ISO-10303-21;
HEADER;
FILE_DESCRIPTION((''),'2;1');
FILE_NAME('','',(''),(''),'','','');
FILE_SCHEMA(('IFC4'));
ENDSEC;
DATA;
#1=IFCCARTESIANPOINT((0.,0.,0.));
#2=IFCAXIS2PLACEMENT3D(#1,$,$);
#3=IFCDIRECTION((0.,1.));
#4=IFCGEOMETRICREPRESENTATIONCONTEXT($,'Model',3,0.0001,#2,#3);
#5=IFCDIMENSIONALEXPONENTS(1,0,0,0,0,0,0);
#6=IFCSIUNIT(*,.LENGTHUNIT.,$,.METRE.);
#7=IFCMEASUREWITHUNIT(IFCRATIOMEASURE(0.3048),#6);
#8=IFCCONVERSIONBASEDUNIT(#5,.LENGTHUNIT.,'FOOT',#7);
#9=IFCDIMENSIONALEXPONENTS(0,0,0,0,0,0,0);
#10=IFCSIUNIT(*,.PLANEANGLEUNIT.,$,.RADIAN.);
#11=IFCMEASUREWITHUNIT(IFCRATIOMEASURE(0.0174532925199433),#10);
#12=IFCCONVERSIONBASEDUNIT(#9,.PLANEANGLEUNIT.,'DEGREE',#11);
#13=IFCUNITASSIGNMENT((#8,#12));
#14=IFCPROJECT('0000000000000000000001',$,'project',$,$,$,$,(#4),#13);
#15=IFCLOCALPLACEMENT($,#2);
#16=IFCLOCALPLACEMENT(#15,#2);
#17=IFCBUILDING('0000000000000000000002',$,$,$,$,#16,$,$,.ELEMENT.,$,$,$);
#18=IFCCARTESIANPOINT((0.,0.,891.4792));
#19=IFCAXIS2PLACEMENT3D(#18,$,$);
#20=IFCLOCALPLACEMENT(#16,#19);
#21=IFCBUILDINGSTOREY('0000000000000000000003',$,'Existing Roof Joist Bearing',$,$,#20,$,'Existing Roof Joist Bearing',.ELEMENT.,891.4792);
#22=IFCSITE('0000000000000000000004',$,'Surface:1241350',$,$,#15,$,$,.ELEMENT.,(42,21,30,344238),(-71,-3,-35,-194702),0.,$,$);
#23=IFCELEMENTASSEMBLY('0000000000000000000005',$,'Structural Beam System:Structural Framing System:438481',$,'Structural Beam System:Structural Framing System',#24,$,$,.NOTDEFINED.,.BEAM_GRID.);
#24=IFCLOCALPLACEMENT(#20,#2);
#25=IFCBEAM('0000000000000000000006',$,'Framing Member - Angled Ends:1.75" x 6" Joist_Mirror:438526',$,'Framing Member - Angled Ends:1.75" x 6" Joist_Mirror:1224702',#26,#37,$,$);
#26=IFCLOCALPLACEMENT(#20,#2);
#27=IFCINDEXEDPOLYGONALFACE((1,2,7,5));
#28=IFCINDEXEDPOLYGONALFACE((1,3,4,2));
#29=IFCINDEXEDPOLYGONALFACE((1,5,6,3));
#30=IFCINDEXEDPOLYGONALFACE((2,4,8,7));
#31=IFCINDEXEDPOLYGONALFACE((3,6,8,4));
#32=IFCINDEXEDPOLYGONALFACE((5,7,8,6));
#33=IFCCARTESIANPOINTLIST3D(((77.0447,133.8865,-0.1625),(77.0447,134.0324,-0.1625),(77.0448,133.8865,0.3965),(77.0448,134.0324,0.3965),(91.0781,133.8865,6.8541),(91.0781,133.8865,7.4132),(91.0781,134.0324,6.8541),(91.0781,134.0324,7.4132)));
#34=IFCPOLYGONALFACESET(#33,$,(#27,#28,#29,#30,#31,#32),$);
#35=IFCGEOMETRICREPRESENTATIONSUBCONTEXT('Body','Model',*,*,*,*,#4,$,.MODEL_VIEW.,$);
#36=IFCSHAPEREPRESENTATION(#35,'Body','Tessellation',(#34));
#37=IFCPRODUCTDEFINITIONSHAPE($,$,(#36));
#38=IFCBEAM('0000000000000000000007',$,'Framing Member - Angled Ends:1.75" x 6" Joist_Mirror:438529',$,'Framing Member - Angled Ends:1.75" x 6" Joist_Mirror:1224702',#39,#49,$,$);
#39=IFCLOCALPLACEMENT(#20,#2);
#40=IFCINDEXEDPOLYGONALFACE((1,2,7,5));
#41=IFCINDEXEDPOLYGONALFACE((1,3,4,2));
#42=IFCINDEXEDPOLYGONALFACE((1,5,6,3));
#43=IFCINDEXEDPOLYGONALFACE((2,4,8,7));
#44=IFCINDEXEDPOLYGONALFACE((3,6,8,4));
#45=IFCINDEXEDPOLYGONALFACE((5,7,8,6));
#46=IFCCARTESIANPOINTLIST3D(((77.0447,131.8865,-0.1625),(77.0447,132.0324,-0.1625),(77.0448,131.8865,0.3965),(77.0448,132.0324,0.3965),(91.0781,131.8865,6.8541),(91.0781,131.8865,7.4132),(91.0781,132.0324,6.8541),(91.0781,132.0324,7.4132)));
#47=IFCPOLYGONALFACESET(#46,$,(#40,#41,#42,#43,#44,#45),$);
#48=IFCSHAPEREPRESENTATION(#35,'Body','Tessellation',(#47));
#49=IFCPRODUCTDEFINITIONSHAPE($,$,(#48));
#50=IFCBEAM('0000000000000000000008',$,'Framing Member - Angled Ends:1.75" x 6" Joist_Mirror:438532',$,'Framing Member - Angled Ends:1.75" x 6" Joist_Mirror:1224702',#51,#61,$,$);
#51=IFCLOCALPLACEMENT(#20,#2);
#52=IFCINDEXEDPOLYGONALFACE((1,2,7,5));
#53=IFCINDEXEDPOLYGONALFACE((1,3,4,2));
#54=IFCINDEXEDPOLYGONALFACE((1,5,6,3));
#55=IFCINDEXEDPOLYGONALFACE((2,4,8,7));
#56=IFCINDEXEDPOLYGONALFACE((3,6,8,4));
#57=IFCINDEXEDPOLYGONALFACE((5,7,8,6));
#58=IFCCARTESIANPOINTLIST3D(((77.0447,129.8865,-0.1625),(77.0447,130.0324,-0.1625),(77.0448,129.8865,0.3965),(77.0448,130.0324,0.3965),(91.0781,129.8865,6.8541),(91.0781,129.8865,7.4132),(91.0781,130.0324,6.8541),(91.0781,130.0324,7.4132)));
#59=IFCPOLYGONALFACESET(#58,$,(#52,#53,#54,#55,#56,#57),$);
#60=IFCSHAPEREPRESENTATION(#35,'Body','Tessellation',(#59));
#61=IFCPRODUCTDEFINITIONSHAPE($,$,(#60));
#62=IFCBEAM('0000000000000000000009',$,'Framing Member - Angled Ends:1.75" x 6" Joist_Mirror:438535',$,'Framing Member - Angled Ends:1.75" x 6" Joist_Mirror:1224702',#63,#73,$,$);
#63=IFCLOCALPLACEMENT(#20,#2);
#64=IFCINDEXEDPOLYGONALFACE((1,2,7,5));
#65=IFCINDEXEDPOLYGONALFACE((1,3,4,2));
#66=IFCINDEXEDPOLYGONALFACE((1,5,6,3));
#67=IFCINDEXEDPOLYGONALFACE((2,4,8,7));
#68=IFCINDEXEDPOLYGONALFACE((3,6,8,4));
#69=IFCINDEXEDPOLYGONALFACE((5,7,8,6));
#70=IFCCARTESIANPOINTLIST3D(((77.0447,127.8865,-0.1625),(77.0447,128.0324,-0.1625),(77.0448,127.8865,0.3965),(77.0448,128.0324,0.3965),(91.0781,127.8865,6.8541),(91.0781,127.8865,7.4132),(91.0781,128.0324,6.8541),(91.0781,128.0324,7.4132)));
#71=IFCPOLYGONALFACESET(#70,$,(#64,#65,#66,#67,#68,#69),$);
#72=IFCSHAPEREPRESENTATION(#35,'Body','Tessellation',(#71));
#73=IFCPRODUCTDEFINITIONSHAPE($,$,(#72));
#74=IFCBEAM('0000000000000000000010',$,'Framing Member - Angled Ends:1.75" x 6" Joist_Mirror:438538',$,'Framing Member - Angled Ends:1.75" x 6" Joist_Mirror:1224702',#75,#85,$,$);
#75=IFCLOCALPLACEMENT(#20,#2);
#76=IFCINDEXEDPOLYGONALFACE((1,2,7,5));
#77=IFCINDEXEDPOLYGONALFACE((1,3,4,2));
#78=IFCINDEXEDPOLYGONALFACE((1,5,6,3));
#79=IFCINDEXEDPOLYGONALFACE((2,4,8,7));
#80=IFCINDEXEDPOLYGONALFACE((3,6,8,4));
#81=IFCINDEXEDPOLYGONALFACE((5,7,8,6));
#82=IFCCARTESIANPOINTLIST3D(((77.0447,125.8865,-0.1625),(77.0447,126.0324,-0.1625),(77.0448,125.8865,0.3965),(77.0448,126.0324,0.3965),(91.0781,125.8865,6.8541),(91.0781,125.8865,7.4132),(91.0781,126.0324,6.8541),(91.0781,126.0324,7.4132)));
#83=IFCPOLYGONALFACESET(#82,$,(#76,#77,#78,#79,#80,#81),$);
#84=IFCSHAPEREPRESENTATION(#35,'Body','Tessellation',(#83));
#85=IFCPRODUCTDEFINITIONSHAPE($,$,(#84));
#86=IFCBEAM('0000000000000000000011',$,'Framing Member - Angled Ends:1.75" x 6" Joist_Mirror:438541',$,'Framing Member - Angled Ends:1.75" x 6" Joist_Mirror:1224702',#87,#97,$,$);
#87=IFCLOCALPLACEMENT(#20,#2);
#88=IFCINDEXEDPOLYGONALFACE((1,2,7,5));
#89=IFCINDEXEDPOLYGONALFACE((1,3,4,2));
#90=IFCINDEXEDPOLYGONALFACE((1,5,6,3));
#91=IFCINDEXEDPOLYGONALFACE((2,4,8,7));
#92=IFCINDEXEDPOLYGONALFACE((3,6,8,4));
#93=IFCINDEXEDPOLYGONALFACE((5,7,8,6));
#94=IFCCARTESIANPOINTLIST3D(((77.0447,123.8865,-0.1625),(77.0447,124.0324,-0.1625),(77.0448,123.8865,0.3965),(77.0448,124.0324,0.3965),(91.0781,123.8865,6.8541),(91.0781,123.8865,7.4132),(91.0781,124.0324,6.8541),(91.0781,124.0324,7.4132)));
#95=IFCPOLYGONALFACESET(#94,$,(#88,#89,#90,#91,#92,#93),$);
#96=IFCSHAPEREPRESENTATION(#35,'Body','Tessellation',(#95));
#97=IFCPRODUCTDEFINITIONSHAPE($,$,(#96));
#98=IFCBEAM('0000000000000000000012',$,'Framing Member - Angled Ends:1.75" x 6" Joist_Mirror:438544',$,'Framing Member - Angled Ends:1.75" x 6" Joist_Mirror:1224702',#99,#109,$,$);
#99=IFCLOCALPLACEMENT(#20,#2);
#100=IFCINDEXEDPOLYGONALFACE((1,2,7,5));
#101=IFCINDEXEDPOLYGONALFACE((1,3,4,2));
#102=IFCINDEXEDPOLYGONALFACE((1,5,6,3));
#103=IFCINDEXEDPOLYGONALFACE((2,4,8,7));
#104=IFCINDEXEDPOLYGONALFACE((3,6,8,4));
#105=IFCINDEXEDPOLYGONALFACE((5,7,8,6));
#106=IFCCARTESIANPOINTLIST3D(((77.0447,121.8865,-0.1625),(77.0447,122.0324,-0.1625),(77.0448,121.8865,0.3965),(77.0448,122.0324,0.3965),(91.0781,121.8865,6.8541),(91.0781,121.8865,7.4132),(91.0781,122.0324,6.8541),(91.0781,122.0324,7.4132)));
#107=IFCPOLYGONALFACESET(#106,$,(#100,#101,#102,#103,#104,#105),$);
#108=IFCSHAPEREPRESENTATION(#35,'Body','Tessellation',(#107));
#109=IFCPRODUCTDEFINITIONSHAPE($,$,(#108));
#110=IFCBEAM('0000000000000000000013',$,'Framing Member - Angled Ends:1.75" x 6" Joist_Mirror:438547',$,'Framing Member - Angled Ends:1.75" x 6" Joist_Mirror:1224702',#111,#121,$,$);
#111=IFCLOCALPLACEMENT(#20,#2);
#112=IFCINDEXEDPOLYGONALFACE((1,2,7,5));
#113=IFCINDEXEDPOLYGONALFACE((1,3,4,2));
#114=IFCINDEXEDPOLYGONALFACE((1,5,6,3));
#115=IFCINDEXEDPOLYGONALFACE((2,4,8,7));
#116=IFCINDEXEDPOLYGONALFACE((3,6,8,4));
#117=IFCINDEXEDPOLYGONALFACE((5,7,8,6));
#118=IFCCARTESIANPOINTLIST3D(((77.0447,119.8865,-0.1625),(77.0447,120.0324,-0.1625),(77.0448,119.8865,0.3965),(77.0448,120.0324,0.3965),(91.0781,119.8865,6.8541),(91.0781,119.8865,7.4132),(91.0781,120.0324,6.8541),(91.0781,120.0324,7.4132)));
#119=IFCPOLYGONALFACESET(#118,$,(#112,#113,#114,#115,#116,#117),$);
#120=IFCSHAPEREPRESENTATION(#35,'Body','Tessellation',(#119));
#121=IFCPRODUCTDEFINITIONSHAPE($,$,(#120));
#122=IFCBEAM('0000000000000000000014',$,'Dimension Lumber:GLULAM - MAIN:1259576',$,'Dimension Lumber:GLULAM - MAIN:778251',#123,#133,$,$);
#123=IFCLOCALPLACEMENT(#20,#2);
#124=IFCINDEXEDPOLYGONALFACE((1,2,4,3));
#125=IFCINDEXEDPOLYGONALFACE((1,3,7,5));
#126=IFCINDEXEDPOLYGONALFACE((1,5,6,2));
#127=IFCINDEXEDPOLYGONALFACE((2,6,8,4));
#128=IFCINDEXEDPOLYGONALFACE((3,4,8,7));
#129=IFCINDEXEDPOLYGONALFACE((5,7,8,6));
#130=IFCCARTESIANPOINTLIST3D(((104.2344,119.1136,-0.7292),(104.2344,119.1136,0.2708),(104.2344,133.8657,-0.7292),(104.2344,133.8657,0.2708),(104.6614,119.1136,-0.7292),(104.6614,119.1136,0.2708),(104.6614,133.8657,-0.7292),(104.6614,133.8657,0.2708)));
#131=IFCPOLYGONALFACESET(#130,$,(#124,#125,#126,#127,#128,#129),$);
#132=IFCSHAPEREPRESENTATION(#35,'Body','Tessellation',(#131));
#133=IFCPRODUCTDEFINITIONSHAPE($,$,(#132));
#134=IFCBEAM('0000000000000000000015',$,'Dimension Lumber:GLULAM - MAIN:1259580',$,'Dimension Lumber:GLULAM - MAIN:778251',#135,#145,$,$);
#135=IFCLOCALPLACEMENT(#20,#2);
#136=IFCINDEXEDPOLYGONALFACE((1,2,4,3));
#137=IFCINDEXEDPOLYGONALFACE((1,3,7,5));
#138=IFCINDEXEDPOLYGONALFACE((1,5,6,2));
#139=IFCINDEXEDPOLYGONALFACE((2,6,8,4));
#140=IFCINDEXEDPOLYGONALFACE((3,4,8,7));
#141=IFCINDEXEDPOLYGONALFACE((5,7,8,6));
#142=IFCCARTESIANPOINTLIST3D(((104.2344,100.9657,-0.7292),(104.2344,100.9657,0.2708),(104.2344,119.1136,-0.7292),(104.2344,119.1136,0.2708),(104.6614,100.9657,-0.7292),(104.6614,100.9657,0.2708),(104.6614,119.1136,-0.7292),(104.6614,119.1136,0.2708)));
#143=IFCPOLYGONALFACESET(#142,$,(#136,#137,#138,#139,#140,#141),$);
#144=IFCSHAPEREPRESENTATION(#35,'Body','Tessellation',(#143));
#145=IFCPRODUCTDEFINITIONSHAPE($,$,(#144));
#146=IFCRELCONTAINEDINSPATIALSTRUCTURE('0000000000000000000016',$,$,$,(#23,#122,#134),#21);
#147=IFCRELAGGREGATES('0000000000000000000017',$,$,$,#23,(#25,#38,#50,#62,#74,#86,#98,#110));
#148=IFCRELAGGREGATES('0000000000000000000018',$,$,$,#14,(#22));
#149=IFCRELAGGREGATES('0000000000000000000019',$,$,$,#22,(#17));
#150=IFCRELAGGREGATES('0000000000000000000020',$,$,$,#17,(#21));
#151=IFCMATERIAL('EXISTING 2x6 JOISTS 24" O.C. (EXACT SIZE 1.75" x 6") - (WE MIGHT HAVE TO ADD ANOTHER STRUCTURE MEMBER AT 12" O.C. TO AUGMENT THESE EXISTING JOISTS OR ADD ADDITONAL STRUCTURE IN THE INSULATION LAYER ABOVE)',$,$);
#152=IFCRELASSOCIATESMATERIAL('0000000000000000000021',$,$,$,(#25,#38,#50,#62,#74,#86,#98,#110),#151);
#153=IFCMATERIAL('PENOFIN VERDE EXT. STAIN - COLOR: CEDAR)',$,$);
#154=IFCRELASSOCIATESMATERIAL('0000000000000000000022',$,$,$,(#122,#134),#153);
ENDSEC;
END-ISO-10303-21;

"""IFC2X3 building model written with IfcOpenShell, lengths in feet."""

from ifc_helpers import new_model, entity, si_unit, converted_unit, direction, frame, frame_2d, origin, origin_2d_with_axis, place, context, subcontext, project, spatial, rectangle, extrude, clip, halfspace, material, element, aggregate, save


model = new_model("IFC2X3")

# Units and contexts
model_context = context("Model", 3, precision=0.0001, world=origin(), true_north=direction((0.0, 1.0)))
body_context = subcontext(model_context, "Body", "Model", "MODEL_VIEW")
ifc_project = project(units=[converted_unit("LENGTHUNIT", "FOOT", entity("IfcRatioMeasure", 0.3048), si_unit("LENGTHUNIT", "METRE"), dimensions=[1, 0, 0, 0, 0, 0, 0]), converted_unit("PLANEANGLEUNIT", "DEGREE", entity("IfcRatioMeasure", 0.0174532925199433), si_unit("PLANEANGLEUNIT", "RADIAN"), dimensions=[0, 0, 0, 0, 0, 0, 0])], contexts=[model_context])

# Site, building, storey
site_placement = place(None, origin())
site = spatial("IfcSite", under=ifc_project, at=site_placement, Name="Surface:1241350", CompositionType="ELEMENT", RefLatitude=(42, 21, 30, 344238), RefLongitude=(-71, -3, -35, -194702), RefElevation=0.0)
building_placement = place(site_placement, origin())
building = spatial("IfcBuilding", under=site, at=building_placement, CompositionType="ELEMENT")
storey_placement = place(building_placement, frame((0.0, 0.0, 891.4792)))
storey = spatial("IfcBuildingStorey", under=building, at=storey_placement, Name="Existing Roof Joist Bearing", LongName="Existing Roof Joist Bearing", CompositionType="ELEMENT", Elevation=891.4792)

# Element assembly, beams
ifc_material_1 = material(Name="EXISTING 2x6 JOISTS 24\" O.C. (EXACT SIZE 1.75\" x 6\") - (WE MIGHT HAVE TO ADD ANOTHER STRUCTURE MEMBER AT 12\" O.C. TO AUGMENT THESE EXISTING JOISTS OR ADD ADDITONAL STRUCTURE IN THE INSULATION LAYER ABOVE)")
assembly_1_placement = place(storey_placement, origin())
assembly_1 = element("IfcElementAssembly", 1, at=assembly_1_placement, inside=storey, Name="Structural Beam System:Structural Framing System:438481", ObjectType="Structural Beam System:Structural Framing System", AssemblyPlace="NOTDEFINED", PredefinedType="BEAM_GRID")
beam_1_placement = place(assembly_1_placement, frame((91.0781, 133.9594, 7.4132), z_axis=(-0.447214, 0.0, 0.894427), x_axis=(-0.894427, 0.0, -0.447214)))
beam_1 = element("IfcBeam", 2, at=beam_1_placement, material=ifc_material_1, Name="Framing Member - Angled Ends:1.75\" x 6\" Joist_Mirror:438526", ObjectType="Framing Member - Angled Ends:1.75\" x 6\" Joist_Mirror:1224702", context=body_context, shape_type="Clipping", body=[
    clip(clip(extrude(rectangle(XDim=0.5, YDim=0.1458, at=frame_2d((0.0, 0.0), x_axis=(1.0, 0.0))), frame((0.0, 0.0, -0.25), z_axis=(1.0, 0.0, 0.0), x_axis=(0.0, 0.0, -1.0)), (0.0, 0.0, 1.0), 15.9398), halfspace(frame((0.0, -0.0729, 0.0), z_axis=(-0.894389, 0.0, -0.447291), x_axis=(0.0, -1.0, 0.0)), False)), halfspace(frame((15.9398, -0.0729, -0.5), z_axis=(0.894389, 0.0, 0.447291), x_axis=(0.0, 1.0, 0.0)), False)),
])
beam_2_placement = place(assembly_1_placement, frame((91.0781, 131.9594, 7.4132), z_axis=(-0.447214, 0.0, 0.894427), x_axis=(-0.894427, 0.0, -0.447214)))
beam_2 = element("IfcBeam", 3, at=beam_2_placement, material=ifc_material_1, Name="Framing Member - Angled Ends:1.75\" x 6\" Joist_Mirror:438529", ObjectType="Framing Member - Angled Ends:1.75\" x 6\" Joist_Mirror:1224702", context=body_context, shape_type="Clipping", body=[
    clip(clip(extrude(rectangle(XDim=0.5, YDim=0.1458, at=frame_2d((0.0, 0.0), x_axis=(1.0, 0.0))), frame((0.0, 0.0, -0.25), z_axis=(1.0, 0.0, 0.0), x_axis=(0.0, 0.0, -1.0)), (0.0, 0.0, 1.0), 15.9398), halfspace(frame((0.0, -0.0729, 0.0), z_axis=(-0.894389, 0.0, -0.447291), x_axis=(0.0, -1.0, 0.0)), False)), halfspace(frame((15.9398, -0.0729, -0.5), z_axis=(0.894389, 0.0, 0.447291), x_axis=(0.0, 1.0, 0.0)), False)),
])
beam_3_placement = place(assembly_1_placement, frame((91.0781, 129.9594, 7.4132), z_axis=(-0.447214, 0.0, 0.894427), x_axis=(-0.894427, 0.0, -0.447214)))
beam_3 = element("IfcBeam", 4, at=beam_3_placement, material=ifc_material_1, Name="Framing Member - Angled Ends:1.75\" x 6\" Joist_Mirror:438532", ObjectType="Framing Member - Angled Ends:1.75\" x 6\" Joist_Mirror:1224702", context=body_context, shape_type="Clipping", body=[
    clip(clip(extrude(rectangle(XDim=0.5, YDim=0.1458, at=frame_2d((0.0, 0.0), x_axis=(1.0, 0.0))), frame((0.0, 0.0, -0.25), z_axis=(1.0, 0.0, 0.0), x_axis=(0.0, 0.0, -1.0)), (0.0, 0.0, 1.0), 15.9398), halfspace(frame((0.0, -0.0729, 0.0), z_axis=(-0.894389, 0.0, -0.447291), x_axis=(0.0, -1.0, 0.0)), False)), halfspace(frame((15.9398, -0.0729, -0.5), z_axis=(0.894389, 0.0, 0.447291), x_axis=(0.0, 1.0, 0.0)), False)),
])
beam_4_placement = place(assembly_1_placement, frame((91.0781, 127.9594, 7.4132), z_axis=(-0.447214, 0.0, 0.894427), x_axis=(-0.894427, 0.0, -0.447214)))
beam_4 = element("IfcBeam", 5, at=beam_4_placement, material=ifc_material_1, Name="Framing Member - Angled Ends:1.75\" x 6\" Joist_Mirror:438535", ObjectType="Framing Member - Angled Ends:1.75\" x 6\" Joist_Mirror:1224702", context=body_context, shape_type="Clipping", body=[
    clip(clip(extrude(rectangle(XDim=0.5, YDim=0.1458, at=frame_2d((0.0, 0.0), x_axis=(1.0, 0.0))), frame((0.0, 0.0, -0.25), z_axis=(1.0, 0.0, 0.0), x_axis=(0.0, 0.0, -1.0)), (0.0, 0.0, 1.0), 15.9398), halfspace(frame((0.0, -0.0729, 0.0), z_axis=(-0.894389, 0.0, -0.447291), x_axis=(0.0, -1.0, 0.0)), False)), halfspace(frame((15.9398, -0.0729, -0.5), z_axis=(0.894389, 0.0, 0.447291), x_axis=(0.0, 1.0, 0.0)), False)),
])
beam_5_placement = place(assembly_1_placement, frame((91.0781, 125.9594, 7.4132), z_axis=(-0.447214, 0.0, 0.894427), x_axis=(-0.894427, 0.0, -0.447214)))
beam_5 = element("IfcBeam", 6, at=beam_5_placement, material=ifc_material_1, Name="Framing Member - Angled Ends:1.75\" x 6\" Joist_Mirror:438538", ObjectType="Framing Member - Angled Ends:1.75\" x 6\" Joist_Mirror:1224702", context=body_context, shape_type="Clipping", body=[
    clip(clip(extrude(rectangle(XDim=0.5, YDim=0.1458, at=frame_2d((0.0, 0.0), x_axis=(1.0, 0.0))), frame((0.0, 0.0, -0.25), z_axis=(1.0, 0.0, 0.0), x_axis=(0.0, 0.0, -1.0)), (0.0, 0.0, 1.0), 15.9398), halfspace(frame((15.9398, -0.0729, -0.5), z_axis=(0.894389, 0.0, 0.447291), x_axis=(0.0, 1.0, 0.0)), False)), halfspace(frame((0.0, -0.0729, 0.0), z_axis=(-0.894389, 0.0, -0.447291), x_axis=(0.0, -1.0, 0.0)), False)),
])
beam_6_placement = place(assembly_1_placement, frame((91.0781, 123.9594, 7.4132), z_axis=(-0.447214, 0.0, 0.894427), x_axis=(-0.894427, 0.0, -0.447214)))
beam_6 = element("IfcBeam", 7, at=beam_6_placement, material=ifc_material_1, Name="Framing Member - Angled Ends:1.75\" x 6\" Joist_Mirror:438541", ObjectType="Framing Member - Angled Ends:1.75\" x 6\" Joist_Mirror:1224702", context=body_context, shape_type="Clipping", body=[
    clip(clip(extrude(rectangle(XDim=0.5, YDim=0.1458, at=frame_2d((0.0, 0.0), x_axis=(1.0, 0.0))), frame((0.0, 0.0, -0.25), z_axis=(1.0, 0.0, 0.0), x_axis=(0.0, 0.0, -1.0)), (0.0, 0.0, 1.0), 15.9398), halfspace(frame((0.0, -0.0729, 0.0), z_axis=(-0.894389, 0.0, -0.447291), x_axis=(0.0, -1.0, 0.0)), False)), halfspace(frame((15.9398, -0.0729, -0.5), z_axis=(0.894389, 0.0, 0.447291), x_axis=(0.0, 1.0, 0.0)), False)),
])
beam_7_placement = place(assembly_1_placement, frame((91.0781, 121.9594, 7.4132), z_axis=(-0.447214, 0.0, 0.894427), x_axis=(-0.894427, 0.0, -0.447214)))
beam_7 = element("IfcBeam", 8, at=beam_7_placement, material=ifc_material_1, Name="Framing Member - Angled Ends:1.75\" x 6\" Joist_Mirror:438544", ObjectType="Framing Member - Angled Ends:1.75\" x 6\" Joist_Mirror:1224702", context=body_context, shape_type="Clipping", body=[
    clip(clip(extrude(rectangle(XDim=0.5, YDim=0.1458, at=frame_2d((0.0, 0.0), x_axis=(1.0, 0.0))), frame((0.0, 0.0, -0.25), z_axis=(1.0, 0.0, 0.0), x_axis=(0.0, 0.0, -1.0)), (0.0, 0.0, 1.0), 15.9398), halfspace(frame((0.0, -0.0729, 0.0), z_axis=(-0.894389, 0.0, -0.447291), x_axis=(0.0, -1.0, 0.0)), False)), halfspace(frame((15.9398, -0.0729, -0.5), z_axis=(0.894389, 0.0, 0.447291), x_axis=(0.0, 1.0, 0.0)), False)),
])
beam_8_placement = place(assembly_1_placement, frame((91.0781, 119.9594, 7.4132), z_axis=(-0.447214, 0.0, 0.894427), x_axis=(-0.894427, 0.0, -0.447214)))
beam_8 = element("IfcBeam", 9, at=beam_8_placement, material=ifc_material_1, Name="Framing Member - Angled Ends:1.75\" x 6\" Joist_Mirror:438547", ObjectType="Framing Member - Angled Ends:1.75\" x 6\" Joist_Mirror:1224702", context=body_context, shape_type="Clipping", body=[
    clip(clip(extrude(rectangle(XDim=0.5, YDim=0.1458, at=frame_2d((0.0, 0.0), x_axis=(1.0, 0.0))), frame((0.0, 0.0, -0.25), z_axis=(1.0, 0.0, 0.0), x_axis=(0.0, 0.0, -1.0)), (0.0, 0.0, 1.0), 15.9398), halfspace(frame((0.0, -0.0729, 0.0), z_axis=(-0.894389, 0.0, -0.447291), x_axis=(0.0, -1.0, 0.0)), False)), halfspace(frame((15.9398, -0.0729, -0.5), z_axis=(0.894389, 0.0, 0.447291), x_axis=(0.0, 1.0, 0.0)), False)),
])
aggregate(assembly_1, [beam_1, beam_2, beam_3, beam_4, beam_5, beam_6, beam_7, beam_8])

# Beams
ifc_material_2 = material(Name="PENOFIN VERDE EXT. STAIN - COLOR: CEDAR)")
beam_9_placement = place(storey_placement, frame((104.4479, 133.8657, 0.0), z_axis=(0.0, 0.0, 1.0), x_axis=(0.0, -1.0, 0.0)))
element("IfcBeam", 10, at=beam_9_placement, inside=storey, material=ifc_material_2, Name="Dimension Lumber:GLULAM - MAIN:1259576", ObjectType="Dimension Lumber:GLULAM - MAIN:778251", context=body_context, shape_type="SweptSolid", body=[
    extrude(rectangle(XDim=1.0, YDim=0.4271, at=origin_2d_with_axis()), frame((0.0, 0.0, -0.2292), z_axis=(1.0, 0.0, 0.0), x_axis=(0.0, 0.0, -1.0)), (0.0, 0.0, 1.0), 14.7521),
])
beam_10_placement = place(storey_placement, frame((104.4479, 119.1136, 0.0), z_axis=(0.0, 0.0, 1.0), x_axis=(0.0, -1.0, 0.0)))
element("IfcBeam", 11, at=beam_10_placement, inside=storey, material=ifc_material_2, Name="Dimension Lumber:GLULAM - MAIN:1259580", ObjectType="Dimension Lumber:GLULAM - MAIN:778251", context=body_context, shape_type="SweptSolid", body=[
    extrude(rectangle(XDim=1.0, YDim=0.4271, at=origin_2d_with_axis()), frame((0.0, 0.0, -0.2292), z_axis=(1.0, 0.0, 0.0), x_axis=(0.0, 0.0, -1.0)), (0.0, 0.0, 1.0), 18.1479),
])

save(model, "model.ifc")
